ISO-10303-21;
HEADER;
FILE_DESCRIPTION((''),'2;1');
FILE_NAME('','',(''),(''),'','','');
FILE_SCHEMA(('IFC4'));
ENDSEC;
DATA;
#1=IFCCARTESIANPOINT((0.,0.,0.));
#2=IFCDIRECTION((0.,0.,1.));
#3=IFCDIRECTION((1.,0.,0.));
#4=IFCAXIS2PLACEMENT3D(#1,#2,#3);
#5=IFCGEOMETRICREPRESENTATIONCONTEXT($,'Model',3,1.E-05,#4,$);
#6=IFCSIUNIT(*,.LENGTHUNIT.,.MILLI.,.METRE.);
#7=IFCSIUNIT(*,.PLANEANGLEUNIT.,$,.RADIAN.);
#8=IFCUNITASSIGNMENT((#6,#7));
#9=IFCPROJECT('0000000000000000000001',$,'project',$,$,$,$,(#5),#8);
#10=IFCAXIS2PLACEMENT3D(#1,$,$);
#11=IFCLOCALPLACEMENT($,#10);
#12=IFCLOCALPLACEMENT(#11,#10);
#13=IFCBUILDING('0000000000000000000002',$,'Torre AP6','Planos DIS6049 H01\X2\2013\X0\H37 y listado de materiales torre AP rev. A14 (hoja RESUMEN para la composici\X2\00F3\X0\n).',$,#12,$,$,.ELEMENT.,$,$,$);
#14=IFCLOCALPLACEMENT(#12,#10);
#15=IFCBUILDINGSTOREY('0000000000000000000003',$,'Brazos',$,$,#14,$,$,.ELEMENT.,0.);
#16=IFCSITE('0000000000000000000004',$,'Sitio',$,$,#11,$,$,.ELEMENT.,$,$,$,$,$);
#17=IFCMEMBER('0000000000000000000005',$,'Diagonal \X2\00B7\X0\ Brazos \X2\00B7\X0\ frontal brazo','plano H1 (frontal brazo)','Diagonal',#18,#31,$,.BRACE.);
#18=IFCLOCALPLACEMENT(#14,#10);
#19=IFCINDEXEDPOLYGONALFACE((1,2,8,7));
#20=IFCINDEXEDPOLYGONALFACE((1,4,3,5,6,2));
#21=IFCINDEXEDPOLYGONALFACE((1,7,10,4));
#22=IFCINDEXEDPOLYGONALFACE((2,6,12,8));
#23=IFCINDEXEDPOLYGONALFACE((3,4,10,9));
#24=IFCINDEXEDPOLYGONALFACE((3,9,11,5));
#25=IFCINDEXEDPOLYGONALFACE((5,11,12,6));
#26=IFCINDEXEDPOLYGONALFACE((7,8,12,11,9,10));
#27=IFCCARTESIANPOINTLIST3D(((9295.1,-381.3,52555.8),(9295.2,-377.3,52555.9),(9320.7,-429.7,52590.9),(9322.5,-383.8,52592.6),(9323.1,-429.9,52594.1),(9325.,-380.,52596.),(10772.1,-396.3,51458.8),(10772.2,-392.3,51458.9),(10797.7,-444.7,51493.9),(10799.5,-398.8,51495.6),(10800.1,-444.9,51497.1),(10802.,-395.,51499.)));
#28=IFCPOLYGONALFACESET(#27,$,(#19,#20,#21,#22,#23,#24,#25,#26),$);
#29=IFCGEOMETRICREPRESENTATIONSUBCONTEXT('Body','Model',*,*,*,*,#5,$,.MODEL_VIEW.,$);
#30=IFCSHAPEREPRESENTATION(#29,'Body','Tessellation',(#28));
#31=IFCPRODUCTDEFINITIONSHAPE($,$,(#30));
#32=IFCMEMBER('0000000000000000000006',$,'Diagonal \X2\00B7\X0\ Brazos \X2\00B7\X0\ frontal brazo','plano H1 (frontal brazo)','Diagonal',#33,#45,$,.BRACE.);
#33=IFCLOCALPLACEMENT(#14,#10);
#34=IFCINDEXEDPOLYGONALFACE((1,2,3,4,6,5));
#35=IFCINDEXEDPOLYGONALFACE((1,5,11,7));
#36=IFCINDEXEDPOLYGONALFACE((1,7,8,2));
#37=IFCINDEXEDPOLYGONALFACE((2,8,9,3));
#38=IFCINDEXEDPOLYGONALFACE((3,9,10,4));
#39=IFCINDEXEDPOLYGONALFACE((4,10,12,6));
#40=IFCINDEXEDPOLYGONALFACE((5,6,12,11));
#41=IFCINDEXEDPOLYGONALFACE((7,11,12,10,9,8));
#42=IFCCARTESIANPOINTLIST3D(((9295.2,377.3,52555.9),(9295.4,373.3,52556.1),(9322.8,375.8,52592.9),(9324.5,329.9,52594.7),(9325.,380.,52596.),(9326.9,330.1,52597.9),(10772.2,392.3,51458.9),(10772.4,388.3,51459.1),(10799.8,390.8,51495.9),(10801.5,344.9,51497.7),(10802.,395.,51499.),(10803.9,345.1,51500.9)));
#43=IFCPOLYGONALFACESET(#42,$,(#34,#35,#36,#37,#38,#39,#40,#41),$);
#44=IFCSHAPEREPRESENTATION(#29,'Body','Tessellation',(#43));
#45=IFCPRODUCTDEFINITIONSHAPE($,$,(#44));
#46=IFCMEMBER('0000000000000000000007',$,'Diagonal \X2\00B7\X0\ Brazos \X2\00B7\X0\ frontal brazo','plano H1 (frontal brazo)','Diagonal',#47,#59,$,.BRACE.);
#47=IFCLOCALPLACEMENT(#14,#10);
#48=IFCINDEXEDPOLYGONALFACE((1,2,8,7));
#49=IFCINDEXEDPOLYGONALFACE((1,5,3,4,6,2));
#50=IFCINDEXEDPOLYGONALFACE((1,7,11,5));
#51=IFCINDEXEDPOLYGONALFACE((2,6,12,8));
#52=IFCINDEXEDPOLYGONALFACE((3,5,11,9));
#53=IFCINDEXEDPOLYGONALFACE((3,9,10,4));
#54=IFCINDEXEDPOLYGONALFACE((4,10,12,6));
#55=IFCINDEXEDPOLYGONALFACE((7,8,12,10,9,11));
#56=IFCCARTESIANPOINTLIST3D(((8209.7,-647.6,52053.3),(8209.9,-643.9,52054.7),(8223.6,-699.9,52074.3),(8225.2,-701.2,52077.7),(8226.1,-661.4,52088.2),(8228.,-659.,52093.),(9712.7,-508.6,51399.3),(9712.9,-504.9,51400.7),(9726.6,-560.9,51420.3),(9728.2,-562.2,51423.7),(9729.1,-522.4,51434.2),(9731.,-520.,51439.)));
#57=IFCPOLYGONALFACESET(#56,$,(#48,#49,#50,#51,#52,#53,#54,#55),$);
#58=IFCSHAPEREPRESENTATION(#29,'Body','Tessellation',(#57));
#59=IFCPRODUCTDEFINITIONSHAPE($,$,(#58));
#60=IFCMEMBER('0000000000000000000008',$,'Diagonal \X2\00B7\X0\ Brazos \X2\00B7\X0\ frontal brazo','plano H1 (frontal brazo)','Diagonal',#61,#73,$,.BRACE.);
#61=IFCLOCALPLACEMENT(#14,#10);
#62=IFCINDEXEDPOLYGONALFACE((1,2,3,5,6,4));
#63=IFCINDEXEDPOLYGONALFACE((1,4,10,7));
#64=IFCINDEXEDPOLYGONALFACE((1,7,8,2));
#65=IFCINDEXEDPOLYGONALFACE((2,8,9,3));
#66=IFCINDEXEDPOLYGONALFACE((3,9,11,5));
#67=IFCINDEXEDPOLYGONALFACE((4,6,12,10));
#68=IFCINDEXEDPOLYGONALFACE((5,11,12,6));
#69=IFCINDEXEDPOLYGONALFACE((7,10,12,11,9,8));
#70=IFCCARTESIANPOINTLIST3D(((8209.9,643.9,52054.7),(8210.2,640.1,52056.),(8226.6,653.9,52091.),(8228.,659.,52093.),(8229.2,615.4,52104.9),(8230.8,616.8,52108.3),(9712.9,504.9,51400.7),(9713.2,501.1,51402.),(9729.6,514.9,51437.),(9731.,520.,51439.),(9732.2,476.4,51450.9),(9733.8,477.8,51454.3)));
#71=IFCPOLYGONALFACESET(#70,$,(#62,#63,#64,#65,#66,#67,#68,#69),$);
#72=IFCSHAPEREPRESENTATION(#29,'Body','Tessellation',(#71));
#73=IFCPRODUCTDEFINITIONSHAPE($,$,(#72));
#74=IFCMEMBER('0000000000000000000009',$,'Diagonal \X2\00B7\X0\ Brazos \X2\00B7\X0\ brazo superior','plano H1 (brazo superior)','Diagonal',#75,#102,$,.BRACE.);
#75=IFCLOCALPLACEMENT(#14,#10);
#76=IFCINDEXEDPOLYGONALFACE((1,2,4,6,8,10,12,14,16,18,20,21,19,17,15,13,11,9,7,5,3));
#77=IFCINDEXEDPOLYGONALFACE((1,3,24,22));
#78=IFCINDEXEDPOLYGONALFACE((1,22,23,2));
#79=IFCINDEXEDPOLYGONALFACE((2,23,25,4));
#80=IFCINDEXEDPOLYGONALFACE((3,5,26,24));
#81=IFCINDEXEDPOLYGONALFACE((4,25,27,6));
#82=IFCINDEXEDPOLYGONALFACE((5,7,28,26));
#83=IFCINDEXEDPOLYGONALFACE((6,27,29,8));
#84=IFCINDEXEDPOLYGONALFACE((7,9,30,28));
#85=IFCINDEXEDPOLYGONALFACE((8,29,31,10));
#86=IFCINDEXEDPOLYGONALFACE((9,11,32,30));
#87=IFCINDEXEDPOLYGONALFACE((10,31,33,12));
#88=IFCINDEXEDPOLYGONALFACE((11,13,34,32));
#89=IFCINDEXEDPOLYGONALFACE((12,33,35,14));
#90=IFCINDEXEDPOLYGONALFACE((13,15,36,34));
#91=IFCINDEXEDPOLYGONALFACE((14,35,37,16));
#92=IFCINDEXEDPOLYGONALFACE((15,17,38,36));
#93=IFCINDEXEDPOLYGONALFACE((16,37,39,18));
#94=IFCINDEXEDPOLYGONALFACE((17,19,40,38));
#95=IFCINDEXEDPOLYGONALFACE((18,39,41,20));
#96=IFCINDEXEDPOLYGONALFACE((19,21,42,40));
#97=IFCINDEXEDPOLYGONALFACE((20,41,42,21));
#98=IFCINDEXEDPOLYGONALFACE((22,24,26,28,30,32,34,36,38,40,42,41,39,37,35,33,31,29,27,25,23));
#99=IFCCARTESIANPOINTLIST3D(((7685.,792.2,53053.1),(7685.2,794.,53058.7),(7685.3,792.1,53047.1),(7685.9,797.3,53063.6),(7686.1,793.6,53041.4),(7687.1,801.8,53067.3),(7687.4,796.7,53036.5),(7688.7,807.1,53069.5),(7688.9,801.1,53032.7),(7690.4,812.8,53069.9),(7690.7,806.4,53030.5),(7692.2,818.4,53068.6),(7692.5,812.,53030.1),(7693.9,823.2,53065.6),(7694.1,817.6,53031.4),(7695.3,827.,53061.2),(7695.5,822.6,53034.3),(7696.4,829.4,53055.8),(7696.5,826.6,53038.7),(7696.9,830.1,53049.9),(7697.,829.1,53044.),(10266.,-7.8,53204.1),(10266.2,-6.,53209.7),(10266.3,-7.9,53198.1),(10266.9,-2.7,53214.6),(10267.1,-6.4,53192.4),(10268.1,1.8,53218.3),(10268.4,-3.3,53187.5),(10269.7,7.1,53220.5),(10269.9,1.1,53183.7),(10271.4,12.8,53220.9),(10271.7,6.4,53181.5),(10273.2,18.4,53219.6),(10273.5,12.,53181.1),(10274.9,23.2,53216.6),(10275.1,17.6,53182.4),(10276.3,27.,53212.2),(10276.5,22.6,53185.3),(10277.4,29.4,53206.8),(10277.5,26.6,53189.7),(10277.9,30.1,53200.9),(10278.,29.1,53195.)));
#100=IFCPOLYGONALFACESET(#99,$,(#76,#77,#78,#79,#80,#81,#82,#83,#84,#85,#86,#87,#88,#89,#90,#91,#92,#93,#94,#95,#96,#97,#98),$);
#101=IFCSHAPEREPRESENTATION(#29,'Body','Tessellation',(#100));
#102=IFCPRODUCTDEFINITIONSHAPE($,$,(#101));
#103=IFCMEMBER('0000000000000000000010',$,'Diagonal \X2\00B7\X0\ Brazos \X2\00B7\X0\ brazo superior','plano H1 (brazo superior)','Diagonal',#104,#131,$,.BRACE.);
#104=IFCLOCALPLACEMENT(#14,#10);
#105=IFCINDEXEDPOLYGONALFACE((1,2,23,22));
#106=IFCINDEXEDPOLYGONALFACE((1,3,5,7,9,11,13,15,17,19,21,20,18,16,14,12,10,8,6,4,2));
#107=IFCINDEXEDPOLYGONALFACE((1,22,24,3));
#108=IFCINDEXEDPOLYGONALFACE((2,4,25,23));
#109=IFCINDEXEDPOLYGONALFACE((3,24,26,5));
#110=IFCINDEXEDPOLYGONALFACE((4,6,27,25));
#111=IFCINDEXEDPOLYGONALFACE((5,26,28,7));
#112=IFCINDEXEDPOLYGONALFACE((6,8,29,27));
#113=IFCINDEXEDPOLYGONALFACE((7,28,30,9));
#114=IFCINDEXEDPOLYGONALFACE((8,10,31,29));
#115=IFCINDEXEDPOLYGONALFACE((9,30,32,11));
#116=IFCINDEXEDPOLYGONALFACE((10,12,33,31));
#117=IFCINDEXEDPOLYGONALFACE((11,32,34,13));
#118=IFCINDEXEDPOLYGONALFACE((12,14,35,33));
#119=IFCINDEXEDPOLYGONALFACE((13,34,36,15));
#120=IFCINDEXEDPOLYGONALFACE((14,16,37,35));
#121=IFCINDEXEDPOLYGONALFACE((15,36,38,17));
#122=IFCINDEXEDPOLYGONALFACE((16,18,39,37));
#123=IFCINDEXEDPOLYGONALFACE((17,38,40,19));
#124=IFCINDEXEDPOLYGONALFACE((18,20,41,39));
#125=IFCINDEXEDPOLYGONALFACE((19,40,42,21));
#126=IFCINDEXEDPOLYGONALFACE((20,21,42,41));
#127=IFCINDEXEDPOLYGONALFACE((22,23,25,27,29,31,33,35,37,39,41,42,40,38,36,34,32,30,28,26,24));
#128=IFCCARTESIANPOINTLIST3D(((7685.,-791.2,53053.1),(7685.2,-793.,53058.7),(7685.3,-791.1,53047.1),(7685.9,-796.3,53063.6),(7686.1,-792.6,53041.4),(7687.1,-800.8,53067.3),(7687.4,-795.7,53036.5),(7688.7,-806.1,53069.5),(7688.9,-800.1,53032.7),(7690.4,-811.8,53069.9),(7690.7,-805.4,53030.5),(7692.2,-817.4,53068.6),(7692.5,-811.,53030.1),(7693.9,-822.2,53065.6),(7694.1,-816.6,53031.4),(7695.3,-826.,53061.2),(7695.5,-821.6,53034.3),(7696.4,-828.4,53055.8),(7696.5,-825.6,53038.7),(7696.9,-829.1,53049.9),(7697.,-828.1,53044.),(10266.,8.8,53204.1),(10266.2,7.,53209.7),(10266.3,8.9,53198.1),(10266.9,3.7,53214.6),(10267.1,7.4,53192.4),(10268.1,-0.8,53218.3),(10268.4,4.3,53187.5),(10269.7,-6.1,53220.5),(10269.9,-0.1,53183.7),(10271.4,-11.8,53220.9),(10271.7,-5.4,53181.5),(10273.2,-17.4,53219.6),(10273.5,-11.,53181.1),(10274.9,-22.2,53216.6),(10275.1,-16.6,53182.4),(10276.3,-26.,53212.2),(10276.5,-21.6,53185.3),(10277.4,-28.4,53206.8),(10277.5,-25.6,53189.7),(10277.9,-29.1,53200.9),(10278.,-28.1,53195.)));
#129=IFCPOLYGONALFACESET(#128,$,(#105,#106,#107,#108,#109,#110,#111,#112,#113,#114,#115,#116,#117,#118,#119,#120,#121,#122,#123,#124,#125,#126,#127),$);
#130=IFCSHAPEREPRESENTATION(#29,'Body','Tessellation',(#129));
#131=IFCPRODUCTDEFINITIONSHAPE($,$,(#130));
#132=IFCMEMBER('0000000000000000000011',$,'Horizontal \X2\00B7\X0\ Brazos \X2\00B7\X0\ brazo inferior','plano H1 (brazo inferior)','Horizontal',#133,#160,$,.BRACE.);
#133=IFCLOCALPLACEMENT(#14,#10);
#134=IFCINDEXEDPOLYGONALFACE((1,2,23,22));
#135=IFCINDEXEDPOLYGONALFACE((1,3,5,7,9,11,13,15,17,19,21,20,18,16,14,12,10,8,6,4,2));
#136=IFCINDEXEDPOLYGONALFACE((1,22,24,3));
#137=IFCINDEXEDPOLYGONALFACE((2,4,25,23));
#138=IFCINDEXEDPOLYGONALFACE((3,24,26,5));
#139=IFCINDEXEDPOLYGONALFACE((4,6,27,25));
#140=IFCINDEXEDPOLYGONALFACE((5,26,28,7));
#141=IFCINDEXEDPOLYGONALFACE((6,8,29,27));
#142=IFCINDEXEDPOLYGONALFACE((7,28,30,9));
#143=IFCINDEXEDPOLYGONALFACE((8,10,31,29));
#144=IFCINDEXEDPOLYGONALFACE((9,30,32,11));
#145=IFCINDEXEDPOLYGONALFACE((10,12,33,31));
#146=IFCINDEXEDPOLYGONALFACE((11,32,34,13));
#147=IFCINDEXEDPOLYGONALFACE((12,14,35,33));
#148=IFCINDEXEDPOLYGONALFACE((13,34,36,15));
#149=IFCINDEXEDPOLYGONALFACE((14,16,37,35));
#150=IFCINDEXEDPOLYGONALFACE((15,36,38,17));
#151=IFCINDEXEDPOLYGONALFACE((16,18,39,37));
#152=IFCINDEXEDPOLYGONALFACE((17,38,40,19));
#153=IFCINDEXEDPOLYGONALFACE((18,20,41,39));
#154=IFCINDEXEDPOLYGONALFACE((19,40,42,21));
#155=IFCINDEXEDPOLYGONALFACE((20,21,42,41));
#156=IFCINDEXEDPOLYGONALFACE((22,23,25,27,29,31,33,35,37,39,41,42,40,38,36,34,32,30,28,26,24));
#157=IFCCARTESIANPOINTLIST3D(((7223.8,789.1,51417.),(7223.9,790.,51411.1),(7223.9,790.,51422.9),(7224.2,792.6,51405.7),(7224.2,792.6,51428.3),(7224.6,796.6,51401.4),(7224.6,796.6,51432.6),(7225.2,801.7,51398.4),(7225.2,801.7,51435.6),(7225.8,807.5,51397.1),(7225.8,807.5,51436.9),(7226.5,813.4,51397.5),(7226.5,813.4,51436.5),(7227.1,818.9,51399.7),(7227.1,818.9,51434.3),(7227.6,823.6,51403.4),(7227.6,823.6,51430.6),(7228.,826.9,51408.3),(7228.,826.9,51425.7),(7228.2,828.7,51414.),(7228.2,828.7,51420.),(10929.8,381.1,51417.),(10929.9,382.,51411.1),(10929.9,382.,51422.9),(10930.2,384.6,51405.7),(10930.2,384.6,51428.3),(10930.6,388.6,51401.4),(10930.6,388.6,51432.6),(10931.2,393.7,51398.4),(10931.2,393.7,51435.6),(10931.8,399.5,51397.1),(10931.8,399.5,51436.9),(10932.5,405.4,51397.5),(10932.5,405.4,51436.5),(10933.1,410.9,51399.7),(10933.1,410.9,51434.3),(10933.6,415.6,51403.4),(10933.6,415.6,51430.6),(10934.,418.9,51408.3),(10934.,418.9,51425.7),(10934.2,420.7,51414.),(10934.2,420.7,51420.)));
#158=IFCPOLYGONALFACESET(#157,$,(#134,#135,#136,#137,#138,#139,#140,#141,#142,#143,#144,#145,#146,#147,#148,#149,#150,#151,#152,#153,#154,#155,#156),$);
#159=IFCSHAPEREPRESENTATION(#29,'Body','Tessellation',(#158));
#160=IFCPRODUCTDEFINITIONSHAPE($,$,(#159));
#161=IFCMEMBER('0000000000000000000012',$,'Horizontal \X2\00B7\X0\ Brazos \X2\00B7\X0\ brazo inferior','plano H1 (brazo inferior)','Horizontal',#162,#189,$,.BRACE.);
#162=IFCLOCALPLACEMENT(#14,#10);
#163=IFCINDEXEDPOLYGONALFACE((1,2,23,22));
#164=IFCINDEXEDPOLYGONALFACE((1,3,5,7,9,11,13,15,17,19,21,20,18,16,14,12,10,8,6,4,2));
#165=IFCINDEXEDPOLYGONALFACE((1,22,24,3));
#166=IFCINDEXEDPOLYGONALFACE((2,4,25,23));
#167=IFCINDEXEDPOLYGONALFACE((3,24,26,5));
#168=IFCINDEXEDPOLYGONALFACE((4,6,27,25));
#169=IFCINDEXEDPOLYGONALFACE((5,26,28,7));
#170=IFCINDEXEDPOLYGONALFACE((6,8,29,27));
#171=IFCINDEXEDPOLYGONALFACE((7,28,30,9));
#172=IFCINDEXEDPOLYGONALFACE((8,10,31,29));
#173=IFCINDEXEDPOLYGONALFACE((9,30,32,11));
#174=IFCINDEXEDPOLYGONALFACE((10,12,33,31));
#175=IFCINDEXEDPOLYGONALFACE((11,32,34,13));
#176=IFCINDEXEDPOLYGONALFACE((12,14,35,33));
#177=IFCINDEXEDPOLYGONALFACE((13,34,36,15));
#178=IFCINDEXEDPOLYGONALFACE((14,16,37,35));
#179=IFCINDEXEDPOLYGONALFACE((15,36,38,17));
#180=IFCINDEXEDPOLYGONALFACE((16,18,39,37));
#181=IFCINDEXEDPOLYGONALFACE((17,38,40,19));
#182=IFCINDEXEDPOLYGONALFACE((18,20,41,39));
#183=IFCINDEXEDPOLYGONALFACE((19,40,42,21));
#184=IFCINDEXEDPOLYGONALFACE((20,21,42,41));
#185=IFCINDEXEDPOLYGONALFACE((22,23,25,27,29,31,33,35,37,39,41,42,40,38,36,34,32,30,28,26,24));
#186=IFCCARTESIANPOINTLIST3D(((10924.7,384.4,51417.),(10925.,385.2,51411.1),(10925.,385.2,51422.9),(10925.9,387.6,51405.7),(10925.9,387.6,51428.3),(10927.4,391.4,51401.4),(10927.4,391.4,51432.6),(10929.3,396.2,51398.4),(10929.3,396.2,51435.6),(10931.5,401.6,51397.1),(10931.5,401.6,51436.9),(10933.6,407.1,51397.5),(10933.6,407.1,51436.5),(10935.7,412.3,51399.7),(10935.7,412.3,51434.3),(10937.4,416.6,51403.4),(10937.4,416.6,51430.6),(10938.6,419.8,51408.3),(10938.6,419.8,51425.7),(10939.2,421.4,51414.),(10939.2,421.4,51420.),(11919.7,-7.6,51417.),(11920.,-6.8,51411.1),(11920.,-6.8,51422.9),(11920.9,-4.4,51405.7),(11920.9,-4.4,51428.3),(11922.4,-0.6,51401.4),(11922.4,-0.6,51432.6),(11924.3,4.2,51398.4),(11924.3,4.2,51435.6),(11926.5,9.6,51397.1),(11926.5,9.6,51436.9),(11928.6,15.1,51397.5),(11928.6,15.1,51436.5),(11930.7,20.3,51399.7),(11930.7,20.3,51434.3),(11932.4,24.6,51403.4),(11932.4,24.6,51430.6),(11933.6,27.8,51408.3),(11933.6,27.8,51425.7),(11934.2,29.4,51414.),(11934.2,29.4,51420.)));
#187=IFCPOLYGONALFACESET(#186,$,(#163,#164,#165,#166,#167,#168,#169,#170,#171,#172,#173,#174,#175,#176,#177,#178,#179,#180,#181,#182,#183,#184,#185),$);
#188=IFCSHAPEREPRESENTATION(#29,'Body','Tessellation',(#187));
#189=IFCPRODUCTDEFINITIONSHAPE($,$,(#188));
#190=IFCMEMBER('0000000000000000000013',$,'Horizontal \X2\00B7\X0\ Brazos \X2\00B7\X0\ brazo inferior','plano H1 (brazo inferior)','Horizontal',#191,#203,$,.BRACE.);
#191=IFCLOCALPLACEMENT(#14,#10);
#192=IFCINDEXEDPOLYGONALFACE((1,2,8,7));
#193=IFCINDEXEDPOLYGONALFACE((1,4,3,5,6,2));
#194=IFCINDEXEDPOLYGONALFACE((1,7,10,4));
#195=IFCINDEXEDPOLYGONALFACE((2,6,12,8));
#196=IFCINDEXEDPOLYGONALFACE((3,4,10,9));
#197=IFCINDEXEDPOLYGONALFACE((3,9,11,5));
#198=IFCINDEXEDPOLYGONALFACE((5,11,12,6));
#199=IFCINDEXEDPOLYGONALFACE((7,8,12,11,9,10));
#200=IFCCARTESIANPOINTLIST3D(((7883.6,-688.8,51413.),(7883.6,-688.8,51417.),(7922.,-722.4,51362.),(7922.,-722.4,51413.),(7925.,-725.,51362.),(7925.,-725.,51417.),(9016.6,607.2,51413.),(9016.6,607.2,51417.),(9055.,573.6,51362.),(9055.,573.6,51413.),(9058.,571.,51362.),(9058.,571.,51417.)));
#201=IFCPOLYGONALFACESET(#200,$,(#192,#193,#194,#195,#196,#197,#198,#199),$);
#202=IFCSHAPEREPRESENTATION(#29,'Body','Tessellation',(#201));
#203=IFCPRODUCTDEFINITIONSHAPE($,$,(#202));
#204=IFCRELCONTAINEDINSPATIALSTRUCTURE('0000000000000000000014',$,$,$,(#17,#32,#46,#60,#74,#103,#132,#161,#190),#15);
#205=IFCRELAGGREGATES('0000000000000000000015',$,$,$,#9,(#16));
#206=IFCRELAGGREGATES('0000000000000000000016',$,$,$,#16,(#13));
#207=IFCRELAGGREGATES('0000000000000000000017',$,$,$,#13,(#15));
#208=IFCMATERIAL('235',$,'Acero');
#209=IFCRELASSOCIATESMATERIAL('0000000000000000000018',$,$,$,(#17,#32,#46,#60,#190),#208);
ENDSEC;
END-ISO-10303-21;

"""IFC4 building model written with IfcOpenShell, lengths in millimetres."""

from ifc_helpers import new_model, si_unit, frame, frame_2d, origin, origin_with_axes, place, context, subcontext, project, spatial, circle, l_section, extrude, material, element, save


model = new_model("IFC4")

# Units and contexts
model_context = context("Model", 3, precision=1e-05, world=origin_with_axes())
body_context = subcontext(model_context, "Body", "Model", "MODEL_VIEW")
ifc_project = project(units=[si_unit("LENGTHUNIT", "METRE", prefix="MILLI"), si_unit("PLANEANGLEUNIT", "RADIAN")], contexts=[model_context])

# Site, building, storey
site_placement = place(None, origin())
site = spatial("IfcSite", under=ifc_project, at=site_placement, Name="Sitio", CompositionType="ELEMENT")
building_placement = place(site_placement, origin())
building = spatial("IfcBuilding", under=site, at=building_placement, Name="Torre AP6", Description="Planos DIS6049 H01–H37 y listado de materiales torre AP rev. A14 (hoja RESUMEN para la composición).", CompositionType="ELEMENT")
storey_placement = place(building_placement, origin())
storey = spatial("IfcBuildingStorey", under=building, at=storey_placement, Name="Brazos", CompositionType="ELEMENT", Elevation=0.0)

# Members
ifc_material_1 = material(Name="235", Category="Acero")
for number, where, z_axis, x_axis, name in (
    (1, (10802.0, -395.0, 51499.0), (-0.802769, 0.008153, 0.596234), (-0.595049, 0.053521, -0.801905), "Diagonal · Brazos · frontal brazo"),
    (2, (10802.0, 395.0, 51499.0), (-0.802769, -0.008153, 0.596234), (-0.595049, -0.053521, -0.801905), "Diagonal · Brazos · frontal brazo"),
):
    element("IfcMember", number, at=place(storey_placement, frame(where, z_axis=z_axis, x_axis=x_axis)), inside=storey, material=ifc_material_1, Name=name, Description="plano H1 (frontal brazo)", ObjectType="Diagonal", PredefinedType="BRACE", context=body_context, shape_type="SweptSolid", body=[
        extrude(l_section(Depth=50.0, Width=50.0, Thickness=4.0, at=frame_2d((25.0, 25.0))), None, (0.0, 0.0, 1.0), 1839.9),
    ])
for number, where, z_axis, x_axis, name in (
    (3, (9731.0, -520.0, 51439.0), (-0.913674, -0.084498, 0.397567), (-0.401755, 0.335963, -0.851893), "Diagonal · Brazos · frontal brazo"),
    (4, (9731.0, 520.0, 51439.0), (-0.913674, 0.084498, 0.397567), (-0.401755, -0.335963, -0.851893), "Diagonal · Brazos · frontal brazo"),
):
    element("IfcMember", number, at=place(storey_placement, frame(where, z_axis=z_axis, x_axis=x_axis)), inside=storey, material=ifc_material_1, Name=name, Description="plano H1 (frontal brazo)", ObjectType="Diagonal", PredefinedType="BRACE", context=body_context, shape_type="SweptSolid", body=[
        extrude(l_section(Depth=45.0, Width=45.0, Thickness=4.0, at=frame_2d((22.5, 22.5))), None, (0.0, 0.0, 1.0), 1645.0),
    ])
for number, where, z_axis, x_axis, name in (
    (5, (7691.0, 811.0, 53050.0), (0.953681, -0.2956, 0.055795), (-0.300728, -0.941427, 0.152572), "Diagonal · Brazos · brazo superior"),
    (6, (10272.0, -10.0, 53201.0), (-0.953681, -0.2956, -0.055795), (-0.300729, 0.941418, 0.152624), "Diagonal · Brazos · brazo superior"),
):
    element("IfcMember", number, at=place(storey_placement, frame(where, z_axis=z_axis, x_axis=x_axis)), inside=storey, Name=name, Description="plano H1 (brazo superior)", ObjectType="Diagonal", PredefinedType="BRACE", context=body_context, shape_type="SweptSolid", body=[
        extrude(circle(Radius=20.0), None, (0.0, 0.0, 1.0), 2706.4),
    ])
member_1_placement = place(storey_placement, frame((7226.0, 809.0, 51417.0), z_axis=(0.993994, -0.109431, 0.0), x_axis=(-0.109431, -0.993994, 0.0)))
element("IfcMember", 7, at=member_1_placement, inside=storey, Name="Horizontal · Brazos · brazo inferior", Description="plano H1 (brazo inferior)", ObjectType="Horizontal", PredefinedType="BRACE", context=body_context, shape_type="SweptSolid", body=[
    extrude(circle(Radius=20.0), None, (0.0, 0.0, 1.0), 3728.4),
])
member_2_placement = place(storey_placement, frame((10932.0, 403.0, 51417.0), z_axis=(0.930399, -0.366549, 0.0), x_axis=(-0.366549, -0.930399, 0.0)))
element("IfcMember", 8, at=member_2_placement, inside=storey, Name="Horizontal · Brazos · brazo inferior", Description="plano H1 (brazo inferior)", ObjectType="Horizontal", PredefinedType="BRACE", context=body_context, shape_type="SweptSolid", body=[
    extrude(circle(Radius=20.0), None, (0.0, 0.0, 1.0), 1069.4),
])
member_3_placement = place(storey_placement, frame((9058.0, 571.0, 51417.0), z_axis=(-0.658176, -0.752865, 0.0), x_axis=(-0.752865, 0.658176, 0.0)))
element("IfcMember", 9, at=member_3_placement, inside=storey, material=ifc_material_1, Name="Horizontal · Brazos · brazo inferior", Description="plano H1 (brazo inferior)", ObjectType="Horizontal", PredefinedType="BRACE", context=body_context, shape_type="SweptSolid", body=[
    extrude(l_section(Depth=55.0, Width=55.0, Thickness=4.0, at=frame_2d((27.5, 27.5))), None, (0.0, 0.0, 1.0), 1721.4),
])

save(model, "model.ifc")
